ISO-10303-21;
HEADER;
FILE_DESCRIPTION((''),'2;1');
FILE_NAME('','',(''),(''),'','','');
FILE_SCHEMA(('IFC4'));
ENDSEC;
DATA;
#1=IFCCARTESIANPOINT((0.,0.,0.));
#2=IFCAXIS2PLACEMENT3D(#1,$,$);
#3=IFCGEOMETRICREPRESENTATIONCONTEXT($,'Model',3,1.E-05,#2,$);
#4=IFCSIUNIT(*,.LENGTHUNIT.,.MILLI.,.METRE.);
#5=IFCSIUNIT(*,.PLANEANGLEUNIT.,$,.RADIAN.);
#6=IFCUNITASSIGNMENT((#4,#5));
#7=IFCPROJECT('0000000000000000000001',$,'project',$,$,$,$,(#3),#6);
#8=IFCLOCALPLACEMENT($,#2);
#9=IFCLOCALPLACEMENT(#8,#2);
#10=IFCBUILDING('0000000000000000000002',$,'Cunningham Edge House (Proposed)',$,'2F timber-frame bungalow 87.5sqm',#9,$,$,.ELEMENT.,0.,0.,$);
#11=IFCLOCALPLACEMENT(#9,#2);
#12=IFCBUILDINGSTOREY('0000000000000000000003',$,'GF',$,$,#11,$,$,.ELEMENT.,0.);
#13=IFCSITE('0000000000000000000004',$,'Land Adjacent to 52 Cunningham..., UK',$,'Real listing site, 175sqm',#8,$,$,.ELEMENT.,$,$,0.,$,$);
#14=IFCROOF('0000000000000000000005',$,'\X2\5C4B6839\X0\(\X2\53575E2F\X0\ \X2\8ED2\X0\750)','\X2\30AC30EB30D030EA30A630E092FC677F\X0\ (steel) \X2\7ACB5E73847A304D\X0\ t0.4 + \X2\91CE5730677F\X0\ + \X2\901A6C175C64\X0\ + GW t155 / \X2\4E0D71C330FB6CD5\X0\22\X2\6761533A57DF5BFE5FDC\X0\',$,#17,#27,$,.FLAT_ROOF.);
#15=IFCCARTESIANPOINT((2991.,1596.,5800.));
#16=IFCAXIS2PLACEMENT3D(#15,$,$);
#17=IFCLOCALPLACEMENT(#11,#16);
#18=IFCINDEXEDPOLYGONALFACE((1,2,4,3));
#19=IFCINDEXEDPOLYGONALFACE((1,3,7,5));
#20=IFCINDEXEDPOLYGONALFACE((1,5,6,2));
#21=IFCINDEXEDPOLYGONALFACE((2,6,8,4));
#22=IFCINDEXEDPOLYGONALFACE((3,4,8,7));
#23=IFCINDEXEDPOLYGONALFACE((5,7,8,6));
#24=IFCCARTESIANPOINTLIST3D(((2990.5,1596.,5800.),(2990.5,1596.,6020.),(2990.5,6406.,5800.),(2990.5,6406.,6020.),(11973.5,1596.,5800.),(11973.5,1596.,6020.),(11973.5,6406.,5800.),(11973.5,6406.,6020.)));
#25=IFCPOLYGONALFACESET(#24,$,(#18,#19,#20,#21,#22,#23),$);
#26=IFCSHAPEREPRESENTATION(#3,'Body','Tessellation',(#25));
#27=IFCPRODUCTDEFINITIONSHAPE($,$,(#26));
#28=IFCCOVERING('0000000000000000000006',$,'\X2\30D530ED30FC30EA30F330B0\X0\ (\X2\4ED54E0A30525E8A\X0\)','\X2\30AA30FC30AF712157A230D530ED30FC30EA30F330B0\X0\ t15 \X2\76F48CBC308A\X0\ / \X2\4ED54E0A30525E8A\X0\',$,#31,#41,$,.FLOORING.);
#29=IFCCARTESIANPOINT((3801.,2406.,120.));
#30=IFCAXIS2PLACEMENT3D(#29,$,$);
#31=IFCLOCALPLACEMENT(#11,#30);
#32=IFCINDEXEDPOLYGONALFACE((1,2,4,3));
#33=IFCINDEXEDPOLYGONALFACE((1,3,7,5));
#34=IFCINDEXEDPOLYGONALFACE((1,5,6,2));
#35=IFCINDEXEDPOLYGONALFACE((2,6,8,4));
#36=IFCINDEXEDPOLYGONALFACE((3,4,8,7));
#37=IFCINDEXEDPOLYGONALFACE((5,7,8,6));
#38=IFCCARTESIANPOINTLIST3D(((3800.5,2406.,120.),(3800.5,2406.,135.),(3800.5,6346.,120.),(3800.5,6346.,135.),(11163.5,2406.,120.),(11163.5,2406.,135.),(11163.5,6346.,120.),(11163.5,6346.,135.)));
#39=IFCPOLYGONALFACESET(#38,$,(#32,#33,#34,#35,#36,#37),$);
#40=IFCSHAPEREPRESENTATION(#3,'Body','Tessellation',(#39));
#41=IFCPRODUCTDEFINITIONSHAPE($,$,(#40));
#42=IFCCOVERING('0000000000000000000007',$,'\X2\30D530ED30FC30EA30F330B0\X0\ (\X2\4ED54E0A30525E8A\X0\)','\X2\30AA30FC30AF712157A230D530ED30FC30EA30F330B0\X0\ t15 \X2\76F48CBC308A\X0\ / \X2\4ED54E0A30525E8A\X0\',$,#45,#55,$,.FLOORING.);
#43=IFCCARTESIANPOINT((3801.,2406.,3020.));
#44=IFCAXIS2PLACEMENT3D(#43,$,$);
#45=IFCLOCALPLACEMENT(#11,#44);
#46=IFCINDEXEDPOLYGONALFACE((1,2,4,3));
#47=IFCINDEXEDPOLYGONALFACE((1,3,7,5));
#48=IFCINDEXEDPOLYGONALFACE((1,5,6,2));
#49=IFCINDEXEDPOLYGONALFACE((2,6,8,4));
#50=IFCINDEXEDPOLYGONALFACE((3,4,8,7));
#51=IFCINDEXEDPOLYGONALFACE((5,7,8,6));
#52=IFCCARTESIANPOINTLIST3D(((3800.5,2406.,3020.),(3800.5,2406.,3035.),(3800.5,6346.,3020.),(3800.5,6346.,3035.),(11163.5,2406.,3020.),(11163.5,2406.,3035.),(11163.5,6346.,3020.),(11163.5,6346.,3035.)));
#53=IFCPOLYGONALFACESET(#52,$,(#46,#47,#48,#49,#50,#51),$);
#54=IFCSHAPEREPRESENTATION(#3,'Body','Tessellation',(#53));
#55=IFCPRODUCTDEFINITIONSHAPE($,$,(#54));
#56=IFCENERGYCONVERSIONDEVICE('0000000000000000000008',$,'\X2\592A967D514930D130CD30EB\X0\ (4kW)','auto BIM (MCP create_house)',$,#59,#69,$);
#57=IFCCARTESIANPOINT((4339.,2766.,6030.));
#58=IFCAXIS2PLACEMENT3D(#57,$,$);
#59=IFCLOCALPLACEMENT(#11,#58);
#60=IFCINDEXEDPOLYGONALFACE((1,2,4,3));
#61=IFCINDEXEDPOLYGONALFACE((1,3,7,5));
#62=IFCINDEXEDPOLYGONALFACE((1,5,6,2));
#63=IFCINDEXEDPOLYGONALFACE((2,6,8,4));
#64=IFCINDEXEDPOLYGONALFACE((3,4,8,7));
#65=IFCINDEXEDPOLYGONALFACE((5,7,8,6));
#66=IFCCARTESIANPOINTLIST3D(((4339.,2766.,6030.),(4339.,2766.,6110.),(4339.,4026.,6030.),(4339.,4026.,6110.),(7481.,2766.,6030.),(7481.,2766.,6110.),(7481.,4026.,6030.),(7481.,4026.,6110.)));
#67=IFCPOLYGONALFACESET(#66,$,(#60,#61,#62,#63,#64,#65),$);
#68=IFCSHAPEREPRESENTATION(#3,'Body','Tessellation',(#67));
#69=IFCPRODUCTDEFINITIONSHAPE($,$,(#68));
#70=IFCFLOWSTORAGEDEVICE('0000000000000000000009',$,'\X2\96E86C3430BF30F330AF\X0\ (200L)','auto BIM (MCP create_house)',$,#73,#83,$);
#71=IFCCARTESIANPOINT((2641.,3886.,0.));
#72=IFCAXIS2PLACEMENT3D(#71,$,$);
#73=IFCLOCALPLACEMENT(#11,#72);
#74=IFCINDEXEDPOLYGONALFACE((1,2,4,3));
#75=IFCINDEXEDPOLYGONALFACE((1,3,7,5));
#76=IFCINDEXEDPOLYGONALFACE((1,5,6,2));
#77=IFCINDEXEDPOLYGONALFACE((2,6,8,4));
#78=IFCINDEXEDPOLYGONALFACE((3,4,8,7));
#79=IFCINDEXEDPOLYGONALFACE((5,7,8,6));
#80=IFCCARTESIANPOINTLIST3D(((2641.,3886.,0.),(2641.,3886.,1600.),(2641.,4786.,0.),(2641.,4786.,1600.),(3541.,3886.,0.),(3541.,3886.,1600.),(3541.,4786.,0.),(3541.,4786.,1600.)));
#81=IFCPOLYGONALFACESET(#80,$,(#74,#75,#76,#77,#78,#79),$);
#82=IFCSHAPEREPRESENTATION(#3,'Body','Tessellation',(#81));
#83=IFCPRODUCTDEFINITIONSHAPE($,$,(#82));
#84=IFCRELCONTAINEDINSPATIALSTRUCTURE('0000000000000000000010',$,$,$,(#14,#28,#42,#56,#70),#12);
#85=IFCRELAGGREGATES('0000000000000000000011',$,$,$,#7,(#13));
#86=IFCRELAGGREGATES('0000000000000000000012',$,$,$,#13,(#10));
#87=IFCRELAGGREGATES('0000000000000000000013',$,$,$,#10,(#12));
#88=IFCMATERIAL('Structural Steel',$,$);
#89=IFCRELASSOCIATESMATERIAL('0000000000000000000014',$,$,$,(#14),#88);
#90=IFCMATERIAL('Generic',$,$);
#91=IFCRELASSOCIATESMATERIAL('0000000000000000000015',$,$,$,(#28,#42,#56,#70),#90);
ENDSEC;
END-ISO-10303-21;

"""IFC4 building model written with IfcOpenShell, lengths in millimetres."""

from ifc_helpers import new_model, si_unit, frame, frame_2d, origin, place, context, project, spatial, rectangle, extrude, material, element, save


model = new_model("IFC4")

# Units and contexts
model_context = context("Model", 3, precision=1e-05, world=origin())
ifc_project = project(units=[si_unit("LENGTHUNIT", "METRE", prefix="MILLI"), si_unit("PLANEANGLEUNIT", "RADIAN")], contexts=[model_context])

# Site, building, storey
site_placement = place(None, origin())
site = spatial("IfcSite", under=ifc_project, at=site_placement, Name="Land Adjacent to 52 Cunningham..., UK", ObjectType="Real listing site, 175sqm", CompositionType="ELEMENT", RefElevation=0.0)
building_placement = place(site_placement, origin())
building = spatial("IfcBuilding", under=site, at=building_placement, Name="Cunningham Edge House (Proposed)", ObjectType="2F timber-frame bungalow 87.5sqm", CompositionType="ELEMENT", ElevationOfRefHeight=0.0, ElevationOfTerrain=0.0)
storey_placement = place(building_placement, origin())
storey = spatial("IfcBuildingStorey", under=building, at=storey_placement, Name="GF", CompositionType="ELEMENT", Elevation=0.0)

# Roof
ifc_material_1 = material(Name="Structural Steel")
for number, where, name in (
    (1, (2991.0, 1596.0, 5800.0), "屋根(南帯 軒750)"),
):
    element("IfcRoof", number, at=place(storey_placement, frame(where)), inside=storey, material=ifc_material_1, Name=name, Description="ガルバリウム鋼板 (steel) 立平葺き t0.4 + 野地板 + 通気層 + GW t155 / 不燃・法22条区域対応", PredefinedType="FLAT_ROOF", context=model_context, shape_type="SweptSolid", body=[
        extrude(rectangle(XDim=8983.0, YDim=4810.0, at=frame_2d((4491.0, 2405.0))), frame((2991.0, 1596.0, 5800.0)), (0.0, 0.0, 1.0), 220.0),
    ])

# Coverings
ifc_material_2 = material(Name="Generic")
covering_1_placement = place(storey_placement, frame((3801.0, 2406.0, 120.0)))
element("IfcCovering", 2, at=covering_1_placement, inside=storey, material=ifc_material_2, Name="フローリング (仕上げ床)", Description="オーク無垢フローリング t15 直貼り / 仕上げ床", PredefinedType="FLOORING", context=model_context, shape_type="SweptSolid", body=[
    extrude(rectangle(XDim=7363.0, YDim=3940.0, at=frame_2d((3681.0, 1970.0))), frame((3801.0, 2406.0, 120.0)), (0.0, 0.0, 1.0), 15.0),
])
covering_2_placement = place(storey_placement, frame((3801.0, 2406.0, 3020.0)))
element("IfcCovering", 3, at=covering_2_placement, inside=storey, material=ifc_material_2, Name="フローリング (仕上げ床)", Description="オーク無垢フローリング t15 直貼り / 仕上げ床", PredefinedType="FLOORING", context=model_context, shape_type="SweptSolid", body=[
    extrude(rectangle(XDim=7363.0, YDim=3940.0, at=frame_2d((3681.0, 1970.0))), frame((3801.0, 2406.0, 3020.0)), (0.0, 0.0, 1.0), 15.0),
])

# Energy conversion device
energy_conversion_device_placement = place(storey_placement, frame((4339.0, 2766.0, 6030.0)))
element("IfcEnergyConversionDevice", 4, at=energy_conversion_device_placement, inside=storey, material=ifc_material_2, Name="太陽光パネル (4kW)", Description="auto BIM (MCP create_house)", context=model_context, shape_type="SweptSolid", body=[
    extrude(rectangle(XDim=3142.0, YDim=1260.0, at=frame_2d((1571.0, 630.0))), frame((4339.0, 2766.0, 6030.0)), (0.0, 0.0, 1.0), 80.0),
])

# Flow storage device
flow_storage_device_placement = place(storey_placement, frame((2641.0, 3886.0, 0.0)))
element("IfcFlowStorageDevice", 5, at=flow_storage_device_placement, inside=storey, material=ifc_material_2, Name="雨水タンク (200L)", Description="auto BIM (MCP create_house)", context=model_context, shape_type="SweptSolid", body=[
    extrude(rectangle(XDim=900.0, YDim=900.0, at=frame_2d((450.0, 450.0))), frame((2641.0, 3886.0, 0.0)), (0.0, 0.0, 1.0), 1600.0),
])

save(model, "model.ifc")
